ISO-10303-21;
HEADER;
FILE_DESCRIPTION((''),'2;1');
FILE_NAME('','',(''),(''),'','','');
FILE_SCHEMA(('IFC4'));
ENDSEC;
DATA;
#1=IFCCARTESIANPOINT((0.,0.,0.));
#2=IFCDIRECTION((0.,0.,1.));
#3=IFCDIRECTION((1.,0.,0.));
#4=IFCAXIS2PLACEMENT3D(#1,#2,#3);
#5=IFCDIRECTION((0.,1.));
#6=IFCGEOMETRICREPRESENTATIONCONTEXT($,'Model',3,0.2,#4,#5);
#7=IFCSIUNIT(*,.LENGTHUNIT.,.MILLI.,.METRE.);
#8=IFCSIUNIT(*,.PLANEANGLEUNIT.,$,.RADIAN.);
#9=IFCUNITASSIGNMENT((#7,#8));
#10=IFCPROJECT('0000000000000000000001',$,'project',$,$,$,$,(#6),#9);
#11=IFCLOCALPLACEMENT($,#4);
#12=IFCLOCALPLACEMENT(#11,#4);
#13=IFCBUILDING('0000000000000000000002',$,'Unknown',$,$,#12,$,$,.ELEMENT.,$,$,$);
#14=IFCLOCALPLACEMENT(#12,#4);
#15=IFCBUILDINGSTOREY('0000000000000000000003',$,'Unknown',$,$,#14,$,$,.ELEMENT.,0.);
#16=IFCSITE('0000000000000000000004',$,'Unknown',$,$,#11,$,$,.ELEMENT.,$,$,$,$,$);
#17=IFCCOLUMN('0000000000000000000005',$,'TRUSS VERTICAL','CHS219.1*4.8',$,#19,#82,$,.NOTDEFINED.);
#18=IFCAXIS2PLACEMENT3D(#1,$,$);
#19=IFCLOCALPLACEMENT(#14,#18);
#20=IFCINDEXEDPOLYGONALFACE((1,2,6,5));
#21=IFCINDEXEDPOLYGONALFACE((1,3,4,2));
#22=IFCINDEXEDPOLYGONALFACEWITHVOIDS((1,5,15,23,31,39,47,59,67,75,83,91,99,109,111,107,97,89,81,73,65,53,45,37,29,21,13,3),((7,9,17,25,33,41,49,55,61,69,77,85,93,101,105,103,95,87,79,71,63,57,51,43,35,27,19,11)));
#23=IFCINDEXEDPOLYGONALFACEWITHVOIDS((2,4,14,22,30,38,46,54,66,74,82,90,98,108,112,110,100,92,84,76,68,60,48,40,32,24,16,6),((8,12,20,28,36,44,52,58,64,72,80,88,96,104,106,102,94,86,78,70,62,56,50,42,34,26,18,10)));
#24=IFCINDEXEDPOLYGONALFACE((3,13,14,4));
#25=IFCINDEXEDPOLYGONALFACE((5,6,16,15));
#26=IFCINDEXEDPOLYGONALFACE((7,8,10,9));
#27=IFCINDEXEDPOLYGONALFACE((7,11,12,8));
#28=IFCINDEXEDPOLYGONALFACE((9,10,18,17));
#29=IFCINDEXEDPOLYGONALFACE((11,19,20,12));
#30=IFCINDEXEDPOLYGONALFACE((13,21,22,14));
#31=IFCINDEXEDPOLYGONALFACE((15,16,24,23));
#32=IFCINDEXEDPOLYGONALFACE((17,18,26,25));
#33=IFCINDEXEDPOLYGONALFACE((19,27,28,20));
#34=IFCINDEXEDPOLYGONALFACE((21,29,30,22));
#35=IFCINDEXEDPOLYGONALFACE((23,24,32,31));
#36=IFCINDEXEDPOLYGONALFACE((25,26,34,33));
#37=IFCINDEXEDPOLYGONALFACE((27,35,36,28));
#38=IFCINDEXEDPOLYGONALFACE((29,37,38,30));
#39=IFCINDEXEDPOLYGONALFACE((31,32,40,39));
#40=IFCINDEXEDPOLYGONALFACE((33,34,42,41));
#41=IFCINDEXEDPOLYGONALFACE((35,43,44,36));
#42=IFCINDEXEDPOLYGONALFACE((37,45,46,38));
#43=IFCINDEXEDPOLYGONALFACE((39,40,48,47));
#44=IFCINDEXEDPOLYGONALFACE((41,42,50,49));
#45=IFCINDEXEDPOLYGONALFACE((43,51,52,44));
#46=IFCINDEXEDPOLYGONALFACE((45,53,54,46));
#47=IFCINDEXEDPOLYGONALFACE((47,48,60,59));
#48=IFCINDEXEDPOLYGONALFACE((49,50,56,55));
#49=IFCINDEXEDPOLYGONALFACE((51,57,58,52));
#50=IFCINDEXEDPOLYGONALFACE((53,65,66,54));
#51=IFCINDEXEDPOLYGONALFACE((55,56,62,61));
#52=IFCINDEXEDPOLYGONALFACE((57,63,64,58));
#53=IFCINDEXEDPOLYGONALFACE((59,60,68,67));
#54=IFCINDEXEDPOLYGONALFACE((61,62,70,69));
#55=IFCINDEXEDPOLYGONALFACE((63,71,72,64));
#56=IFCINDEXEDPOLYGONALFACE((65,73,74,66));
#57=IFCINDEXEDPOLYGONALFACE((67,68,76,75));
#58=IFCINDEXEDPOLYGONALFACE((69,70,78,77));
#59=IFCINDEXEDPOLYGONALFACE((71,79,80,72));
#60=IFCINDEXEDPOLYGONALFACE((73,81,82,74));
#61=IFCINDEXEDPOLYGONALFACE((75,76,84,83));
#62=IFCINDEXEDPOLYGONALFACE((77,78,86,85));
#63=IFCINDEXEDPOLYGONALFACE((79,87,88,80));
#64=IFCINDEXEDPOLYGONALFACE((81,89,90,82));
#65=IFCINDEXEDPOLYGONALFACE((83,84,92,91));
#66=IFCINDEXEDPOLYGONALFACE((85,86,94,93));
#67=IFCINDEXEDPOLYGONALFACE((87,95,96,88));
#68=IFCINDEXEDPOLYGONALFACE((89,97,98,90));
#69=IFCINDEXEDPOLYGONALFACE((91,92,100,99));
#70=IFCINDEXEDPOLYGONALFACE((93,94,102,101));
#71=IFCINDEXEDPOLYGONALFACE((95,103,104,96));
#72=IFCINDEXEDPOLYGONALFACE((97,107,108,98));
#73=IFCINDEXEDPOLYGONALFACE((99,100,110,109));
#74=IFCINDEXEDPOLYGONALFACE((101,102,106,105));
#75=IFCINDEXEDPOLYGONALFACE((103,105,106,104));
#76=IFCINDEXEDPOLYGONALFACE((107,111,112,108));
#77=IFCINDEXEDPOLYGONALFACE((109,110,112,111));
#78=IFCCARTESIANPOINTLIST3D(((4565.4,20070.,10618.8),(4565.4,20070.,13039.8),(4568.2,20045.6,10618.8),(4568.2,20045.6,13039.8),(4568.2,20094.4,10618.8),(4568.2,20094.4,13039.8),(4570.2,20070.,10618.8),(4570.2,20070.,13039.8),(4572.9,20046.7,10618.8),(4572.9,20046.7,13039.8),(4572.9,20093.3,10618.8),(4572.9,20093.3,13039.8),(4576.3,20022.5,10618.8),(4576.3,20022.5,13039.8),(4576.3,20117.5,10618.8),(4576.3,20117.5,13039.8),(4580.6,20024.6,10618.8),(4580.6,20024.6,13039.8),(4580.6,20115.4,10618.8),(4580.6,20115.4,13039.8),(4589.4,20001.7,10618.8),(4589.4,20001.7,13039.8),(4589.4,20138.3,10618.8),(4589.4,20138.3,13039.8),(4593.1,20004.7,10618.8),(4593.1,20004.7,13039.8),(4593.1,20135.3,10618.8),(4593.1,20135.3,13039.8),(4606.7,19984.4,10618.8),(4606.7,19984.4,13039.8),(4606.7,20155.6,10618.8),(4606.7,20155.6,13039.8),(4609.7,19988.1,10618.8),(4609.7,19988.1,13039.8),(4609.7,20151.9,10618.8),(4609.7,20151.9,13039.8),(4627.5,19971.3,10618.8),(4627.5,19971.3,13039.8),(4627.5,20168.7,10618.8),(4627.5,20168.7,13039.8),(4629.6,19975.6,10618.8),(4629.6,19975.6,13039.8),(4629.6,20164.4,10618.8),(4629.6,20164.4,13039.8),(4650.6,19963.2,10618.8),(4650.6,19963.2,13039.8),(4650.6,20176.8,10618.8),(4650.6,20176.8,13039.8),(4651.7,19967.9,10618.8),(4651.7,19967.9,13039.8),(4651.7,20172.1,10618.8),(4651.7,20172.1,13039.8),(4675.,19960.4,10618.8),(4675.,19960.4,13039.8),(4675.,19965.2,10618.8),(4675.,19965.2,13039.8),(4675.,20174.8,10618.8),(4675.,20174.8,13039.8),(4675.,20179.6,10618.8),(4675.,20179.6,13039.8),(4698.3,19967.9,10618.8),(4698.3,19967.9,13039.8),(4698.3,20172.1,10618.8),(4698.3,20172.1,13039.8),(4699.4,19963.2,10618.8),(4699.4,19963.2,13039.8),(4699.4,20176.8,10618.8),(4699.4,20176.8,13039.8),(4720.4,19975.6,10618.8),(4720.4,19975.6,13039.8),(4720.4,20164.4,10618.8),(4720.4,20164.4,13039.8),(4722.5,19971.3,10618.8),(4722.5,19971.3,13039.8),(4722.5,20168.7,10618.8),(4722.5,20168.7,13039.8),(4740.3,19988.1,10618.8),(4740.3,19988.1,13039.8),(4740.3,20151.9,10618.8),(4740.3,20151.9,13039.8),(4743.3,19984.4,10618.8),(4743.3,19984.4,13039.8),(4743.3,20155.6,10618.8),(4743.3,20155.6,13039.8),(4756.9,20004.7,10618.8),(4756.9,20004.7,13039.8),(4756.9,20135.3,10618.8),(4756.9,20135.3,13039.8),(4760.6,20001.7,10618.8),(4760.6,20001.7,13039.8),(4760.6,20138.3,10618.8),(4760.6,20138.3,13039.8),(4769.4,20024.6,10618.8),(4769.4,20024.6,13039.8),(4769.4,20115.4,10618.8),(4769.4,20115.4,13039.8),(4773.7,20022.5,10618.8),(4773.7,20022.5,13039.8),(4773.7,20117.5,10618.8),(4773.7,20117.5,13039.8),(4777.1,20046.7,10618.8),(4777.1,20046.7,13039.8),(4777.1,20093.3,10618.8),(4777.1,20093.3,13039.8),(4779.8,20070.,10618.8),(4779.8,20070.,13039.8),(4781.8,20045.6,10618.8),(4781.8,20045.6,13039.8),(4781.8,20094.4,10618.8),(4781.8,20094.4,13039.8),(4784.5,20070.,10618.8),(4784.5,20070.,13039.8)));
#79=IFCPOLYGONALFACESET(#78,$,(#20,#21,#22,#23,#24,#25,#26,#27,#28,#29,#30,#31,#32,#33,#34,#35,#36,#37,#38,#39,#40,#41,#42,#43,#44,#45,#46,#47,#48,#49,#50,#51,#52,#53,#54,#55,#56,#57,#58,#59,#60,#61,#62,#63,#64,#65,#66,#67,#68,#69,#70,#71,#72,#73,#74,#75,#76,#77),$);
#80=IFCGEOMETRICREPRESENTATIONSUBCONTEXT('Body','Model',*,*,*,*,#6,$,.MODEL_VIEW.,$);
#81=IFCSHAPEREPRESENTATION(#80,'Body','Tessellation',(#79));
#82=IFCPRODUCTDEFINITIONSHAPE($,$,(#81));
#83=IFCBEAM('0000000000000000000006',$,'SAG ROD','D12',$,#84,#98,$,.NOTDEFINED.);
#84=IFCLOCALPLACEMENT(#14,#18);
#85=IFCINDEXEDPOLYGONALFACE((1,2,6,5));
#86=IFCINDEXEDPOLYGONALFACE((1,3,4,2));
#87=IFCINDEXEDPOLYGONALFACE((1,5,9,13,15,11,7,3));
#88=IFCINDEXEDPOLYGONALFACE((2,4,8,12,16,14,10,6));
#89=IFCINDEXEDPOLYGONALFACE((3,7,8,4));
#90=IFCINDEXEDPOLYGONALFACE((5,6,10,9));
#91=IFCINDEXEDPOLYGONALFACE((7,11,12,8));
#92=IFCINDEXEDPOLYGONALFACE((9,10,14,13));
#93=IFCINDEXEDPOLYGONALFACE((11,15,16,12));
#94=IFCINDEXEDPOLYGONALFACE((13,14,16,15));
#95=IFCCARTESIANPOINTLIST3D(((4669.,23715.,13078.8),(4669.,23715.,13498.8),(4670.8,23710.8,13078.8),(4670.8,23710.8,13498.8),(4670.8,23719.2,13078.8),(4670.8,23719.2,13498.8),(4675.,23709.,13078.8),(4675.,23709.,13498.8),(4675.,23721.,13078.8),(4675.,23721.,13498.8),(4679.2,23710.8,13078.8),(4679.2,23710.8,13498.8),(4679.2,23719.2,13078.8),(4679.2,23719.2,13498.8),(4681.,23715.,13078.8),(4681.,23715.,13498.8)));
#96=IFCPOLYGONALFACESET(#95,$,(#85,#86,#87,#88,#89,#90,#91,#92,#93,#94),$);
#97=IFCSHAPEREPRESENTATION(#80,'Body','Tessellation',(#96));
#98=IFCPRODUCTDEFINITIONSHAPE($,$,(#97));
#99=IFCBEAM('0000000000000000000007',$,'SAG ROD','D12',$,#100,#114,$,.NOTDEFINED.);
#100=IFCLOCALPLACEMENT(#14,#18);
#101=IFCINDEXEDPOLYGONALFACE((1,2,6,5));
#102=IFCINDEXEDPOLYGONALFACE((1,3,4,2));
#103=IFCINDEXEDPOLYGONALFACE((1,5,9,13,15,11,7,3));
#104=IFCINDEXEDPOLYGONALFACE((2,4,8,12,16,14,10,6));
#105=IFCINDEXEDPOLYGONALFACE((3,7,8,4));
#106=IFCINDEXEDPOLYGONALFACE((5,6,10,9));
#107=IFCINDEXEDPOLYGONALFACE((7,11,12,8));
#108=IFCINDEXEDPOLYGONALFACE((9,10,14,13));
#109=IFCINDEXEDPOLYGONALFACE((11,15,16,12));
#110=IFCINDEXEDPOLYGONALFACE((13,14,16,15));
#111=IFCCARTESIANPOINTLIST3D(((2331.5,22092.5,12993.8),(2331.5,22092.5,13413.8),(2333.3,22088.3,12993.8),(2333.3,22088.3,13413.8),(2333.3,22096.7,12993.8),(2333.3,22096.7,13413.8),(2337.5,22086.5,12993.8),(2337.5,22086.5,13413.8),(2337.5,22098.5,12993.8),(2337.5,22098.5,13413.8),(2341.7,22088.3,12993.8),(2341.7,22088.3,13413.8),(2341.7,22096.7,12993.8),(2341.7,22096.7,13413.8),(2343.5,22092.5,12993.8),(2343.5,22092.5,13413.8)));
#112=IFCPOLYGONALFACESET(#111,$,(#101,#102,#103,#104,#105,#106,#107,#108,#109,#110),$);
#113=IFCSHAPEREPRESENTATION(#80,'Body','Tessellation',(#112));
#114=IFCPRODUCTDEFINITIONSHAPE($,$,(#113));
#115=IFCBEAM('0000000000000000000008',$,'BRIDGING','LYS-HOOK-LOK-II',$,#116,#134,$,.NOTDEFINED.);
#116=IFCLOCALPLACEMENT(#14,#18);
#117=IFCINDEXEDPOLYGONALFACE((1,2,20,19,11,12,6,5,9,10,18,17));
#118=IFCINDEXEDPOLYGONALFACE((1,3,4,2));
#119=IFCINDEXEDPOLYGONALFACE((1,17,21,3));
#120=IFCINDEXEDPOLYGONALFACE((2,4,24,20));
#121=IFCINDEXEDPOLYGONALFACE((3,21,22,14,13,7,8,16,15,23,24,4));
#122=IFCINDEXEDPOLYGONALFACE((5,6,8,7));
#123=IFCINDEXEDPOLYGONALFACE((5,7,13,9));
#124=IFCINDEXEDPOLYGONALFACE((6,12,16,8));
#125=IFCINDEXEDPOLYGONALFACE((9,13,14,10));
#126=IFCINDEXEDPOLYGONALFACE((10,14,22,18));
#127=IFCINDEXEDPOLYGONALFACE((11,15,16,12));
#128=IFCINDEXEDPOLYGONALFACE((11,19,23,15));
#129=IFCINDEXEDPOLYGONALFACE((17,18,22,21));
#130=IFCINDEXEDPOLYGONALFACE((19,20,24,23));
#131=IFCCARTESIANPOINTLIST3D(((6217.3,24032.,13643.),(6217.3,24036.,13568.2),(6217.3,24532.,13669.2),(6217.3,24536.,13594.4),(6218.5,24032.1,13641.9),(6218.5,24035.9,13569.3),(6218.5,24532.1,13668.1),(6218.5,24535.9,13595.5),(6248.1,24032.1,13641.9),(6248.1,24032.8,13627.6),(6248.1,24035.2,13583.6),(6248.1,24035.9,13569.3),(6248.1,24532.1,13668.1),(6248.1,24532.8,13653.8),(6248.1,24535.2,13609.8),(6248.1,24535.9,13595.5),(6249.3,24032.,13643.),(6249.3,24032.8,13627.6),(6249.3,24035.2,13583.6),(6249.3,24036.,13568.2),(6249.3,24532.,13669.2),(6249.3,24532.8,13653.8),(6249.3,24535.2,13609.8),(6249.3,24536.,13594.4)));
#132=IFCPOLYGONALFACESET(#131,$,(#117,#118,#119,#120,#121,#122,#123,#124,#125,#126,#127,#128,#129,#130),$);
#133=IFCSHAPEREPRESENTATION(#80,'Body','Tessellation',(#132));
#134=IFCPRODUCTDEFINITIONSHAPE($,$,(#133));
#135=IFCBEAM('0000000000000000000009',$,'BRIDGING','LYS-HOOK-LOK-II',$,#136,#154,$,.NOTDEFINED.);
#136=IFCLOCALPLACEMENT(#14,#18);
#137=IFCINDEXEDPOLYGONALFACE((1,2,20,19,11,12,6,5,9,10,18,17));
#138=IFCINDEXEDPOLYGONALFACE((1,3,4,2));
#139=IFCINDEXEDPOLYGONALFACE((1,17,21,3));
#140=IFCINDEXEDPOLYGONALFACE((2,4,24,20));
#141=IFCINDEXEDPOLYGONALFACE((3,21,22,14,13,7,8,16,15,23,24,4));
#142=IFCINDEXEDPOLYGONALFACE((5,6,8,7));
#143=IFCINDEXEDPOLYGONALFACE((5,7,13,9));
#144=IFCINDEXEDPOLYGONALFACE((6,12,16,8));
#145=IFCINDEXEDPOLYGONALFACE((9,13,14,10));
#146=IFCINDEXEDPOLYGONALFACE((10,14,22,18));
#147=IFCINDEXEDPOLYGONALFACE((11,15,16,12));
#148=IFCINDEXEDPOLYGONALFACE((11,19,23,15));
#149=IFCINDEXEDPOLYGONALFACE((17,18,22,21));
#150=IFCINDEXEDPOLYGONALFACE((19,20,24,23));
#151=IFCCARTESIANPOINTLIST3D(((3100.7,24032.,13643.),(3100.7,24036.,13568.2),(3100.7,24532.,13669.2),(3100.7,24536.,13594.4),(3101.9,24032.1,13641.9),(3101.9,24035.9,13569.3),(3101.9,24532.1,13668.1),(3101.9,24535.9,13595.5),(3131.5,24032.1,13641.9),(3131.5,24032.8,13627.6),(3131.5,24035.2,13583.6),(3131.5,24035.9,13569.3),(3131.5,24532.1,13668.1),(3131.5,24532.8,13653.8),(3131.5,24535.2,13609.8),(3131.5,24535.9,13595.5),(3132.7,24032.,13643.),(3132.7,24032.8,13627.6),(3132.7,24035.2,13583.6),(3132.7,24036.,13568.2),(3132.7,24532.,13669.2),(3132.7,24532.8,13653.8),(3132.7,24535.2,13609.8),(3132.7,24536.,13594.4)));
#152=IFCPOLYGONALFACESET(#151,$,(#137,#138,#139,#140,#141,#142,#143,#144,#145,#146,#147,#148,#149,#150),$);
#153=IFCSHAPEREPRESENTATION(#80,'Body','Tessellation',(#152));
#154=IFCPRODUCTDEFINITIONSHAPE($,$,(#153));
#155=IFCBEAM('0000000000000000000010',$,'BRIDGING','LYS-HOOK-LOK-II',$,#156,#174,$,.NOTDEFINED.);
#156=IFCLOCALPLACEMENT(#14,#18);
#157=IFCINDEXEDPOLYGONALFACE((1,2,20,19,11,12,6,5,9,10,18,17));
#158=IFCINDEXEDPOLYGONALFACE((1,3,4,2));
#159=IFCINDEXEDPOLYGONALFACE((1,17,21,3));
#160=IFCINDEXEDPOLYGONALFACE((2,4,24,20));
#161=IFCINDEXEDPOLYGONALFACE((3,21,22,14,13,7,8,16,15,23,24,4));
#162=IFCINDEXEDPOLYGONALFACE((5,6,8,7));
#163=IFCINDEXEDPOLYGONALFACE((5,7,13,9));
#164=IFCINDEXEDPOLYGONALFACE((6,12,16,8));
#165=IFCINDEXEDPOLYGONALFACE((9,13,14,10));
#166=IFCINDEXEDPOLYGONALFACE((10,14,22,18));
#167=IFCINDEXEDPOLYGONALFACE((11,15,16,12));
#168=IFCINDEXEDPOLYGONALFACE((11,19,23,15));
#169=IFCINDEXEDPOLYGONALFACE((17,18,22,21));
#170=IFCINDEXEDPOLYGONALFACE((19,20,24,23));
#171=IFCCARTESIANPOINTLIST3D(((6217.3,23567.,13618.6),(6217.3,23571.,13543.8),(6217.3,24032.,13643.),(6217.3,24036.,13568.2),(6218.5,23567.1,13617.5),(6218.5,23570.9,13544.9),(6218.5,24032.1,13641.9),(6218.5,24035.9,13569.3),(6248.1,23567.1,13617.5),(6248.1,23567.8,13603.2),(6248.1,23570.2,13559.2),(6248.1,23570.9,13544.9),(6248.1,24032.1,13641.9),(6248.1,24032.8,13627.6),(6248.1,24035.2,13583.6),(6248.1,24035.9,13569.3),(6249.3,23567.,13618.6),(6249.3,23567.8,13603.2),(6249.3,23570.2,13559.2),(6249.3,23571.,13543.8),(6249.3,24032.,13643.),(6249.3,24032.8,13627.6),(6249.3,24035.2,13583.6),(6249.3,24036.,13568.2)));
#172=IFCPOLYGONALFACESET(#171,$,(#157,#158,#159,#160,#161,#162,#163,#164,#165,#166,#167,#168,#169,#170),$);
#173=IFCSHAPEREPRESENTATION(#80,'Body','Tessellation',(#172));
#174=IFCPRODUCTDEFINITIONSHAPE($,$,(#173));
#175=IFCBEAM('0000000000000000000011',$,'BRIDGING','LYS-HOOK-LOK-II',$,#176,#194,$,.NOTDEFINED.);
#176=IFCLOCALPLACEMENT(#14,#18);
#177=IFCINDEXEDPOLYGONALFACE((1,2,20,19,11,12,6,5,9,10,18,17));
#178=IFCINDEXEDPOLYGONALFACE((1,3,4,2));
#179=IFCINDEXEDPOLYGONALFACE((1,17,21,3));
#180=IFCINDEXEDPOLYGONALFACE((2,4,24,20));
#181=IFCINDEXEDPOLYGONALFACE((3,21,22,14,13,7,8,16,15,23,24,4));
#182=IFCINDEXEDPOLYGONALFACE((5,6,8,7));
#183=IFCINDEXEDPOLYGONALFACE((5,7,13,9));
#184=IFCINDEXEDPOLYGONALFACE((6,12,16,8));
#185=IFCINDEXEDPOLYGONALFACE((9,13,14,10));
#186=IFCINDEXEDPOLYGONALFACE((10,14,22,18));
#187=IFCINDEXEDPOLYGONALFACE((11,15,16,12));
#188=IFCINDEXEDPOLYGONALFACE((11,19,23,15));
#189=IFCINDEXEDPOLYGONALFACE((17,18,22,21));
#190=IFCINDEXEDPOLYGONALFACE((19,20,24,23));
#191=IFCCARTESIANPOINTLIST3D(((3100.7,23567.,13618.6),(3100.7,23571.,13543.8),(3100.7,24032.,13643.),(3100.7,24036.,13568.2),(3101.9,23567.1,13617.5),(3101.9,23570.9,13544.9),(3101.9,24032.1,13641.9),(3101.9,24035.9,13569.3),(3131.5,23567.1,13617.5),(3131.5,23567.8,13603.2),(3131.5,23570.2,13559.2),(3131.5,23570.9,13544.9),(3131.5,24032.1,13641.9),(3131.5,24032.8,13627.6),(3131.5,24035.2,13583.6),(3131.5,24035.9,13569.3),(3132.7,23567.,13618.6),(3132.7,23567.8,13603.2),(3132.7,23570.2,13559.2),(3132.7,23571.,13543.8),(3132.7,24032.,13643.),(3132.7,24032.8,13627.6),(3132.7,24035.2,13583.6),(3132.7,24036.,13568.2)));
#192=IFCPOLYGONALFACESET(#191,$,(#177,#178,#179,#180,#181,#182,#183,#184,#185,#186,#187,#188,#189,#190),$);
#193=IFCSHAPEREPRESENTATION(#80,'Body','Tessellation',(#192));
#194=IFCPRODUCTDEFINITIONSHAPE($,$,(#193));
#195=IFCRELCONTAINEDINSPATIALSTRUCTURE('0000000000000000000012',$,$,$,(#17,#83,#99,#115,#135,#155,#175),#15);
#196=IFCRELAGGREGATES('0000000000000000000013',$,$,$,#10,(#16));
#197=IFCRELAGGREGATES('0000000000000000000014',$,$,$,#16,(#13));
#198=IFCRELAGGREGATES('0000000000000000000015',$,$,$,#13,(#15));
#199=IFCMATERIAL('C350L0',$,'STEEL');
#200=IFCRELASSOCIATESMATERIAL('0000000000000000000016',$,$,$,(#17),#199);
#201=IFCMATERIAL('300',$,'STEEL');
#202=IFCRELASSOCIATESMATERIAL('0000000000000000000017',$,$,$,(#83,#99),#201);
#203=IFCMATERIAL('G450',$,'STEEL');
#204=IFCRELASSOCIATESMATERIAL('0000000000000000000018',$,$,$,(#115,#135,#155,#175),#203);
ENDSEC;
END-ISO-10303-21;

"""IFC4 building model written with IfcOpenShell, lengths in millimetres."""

from ifc_helpers import new_model, si_unit, direction, frame, origin_with_axes, place, context, subcontext, project, spatial, line, indexed_curve, outline, extrude, material, element, save


model = new_model("IFC4")

# Units and contexts
model_context = context("Model", 3, precision=0.2, world=origin_with_axes(), true_north=direction((0.0, 1.0)))
body_context = subcontext(model_context, "Body", "Model", "MODEL_VIEW")
ifc_project = project(units=[si_unit("LENGTHUNIT", "METRE", prefix="MILLI"), si_unit("PLANEANGLEUNIT", "RADIAN")], contexts=[model_context])

# Site, building, storey
site_placement = place(None, origin_with_axes())
site = spatial("IfcSite", under=ifc_project, at=site_placement, Name="Unknown", CompositionType="ELEMENT")
building_placement = place(site_placement, origin_with_axes())
building = spatial("IfcBuilding", under=site, at=building_placement, Name="Unknown", CompositionType="ELEMENT")
storey_placement = place(building_placement, origin_with_axes())
storey = spatial("IfcBuildingStorey", under=building, at=storey_placement, Name="Unknown", CompositionType="ELEMENT", Elevation=0.0)

# Column
ifc_material_1 = material(Name="C350L0", Category="STEEL")
column_placement = place(storey_placement, frame((4675.0, 20070.0, 10618.8), z_axis=(-1.0, 0.0, 0.0), x_axis=(0.0, 0.0, 1.0)))
element("IfcColumn", 1, at=column_placement, inside=storey, material=ifc_material_1, Name="TRUSS VERTICAL", Description="CHS219.1*4.8", PredefinedType="NOTDEFINED", context=body_context, shape_type="SolidModel", body=[
    extrude(outline(indexed_curve([(109.5, 0.0), (106.8, 24.4), (98.7, 47.5), (85.6, 68.3), (68.3, 85.6), (47.5, 98.7), (24.4, 106.8), (0.0, 109.5), (-24.4, 106.8), (-47.5, 98.7), (-68.3, 85.6), (-85.6, 68.3), (-98.7, 47.5), (-106.8, 24.4), (-109.5, 0.0), (-106.8, -24.4), (-98.7, -47.5), (-85.6, -68.3), (-68.3, -85.6), (-47.5, -98.7), (-24.4, -106.8), (0.0, -109.5), (24.4, -106.8), (47.5, -98.7), (68.3, -85.6), (85.6, -68.3), (98.7, -47.5), (106.8, -24.4)], segments=[line(1, 2, 3, 4, 5, 6, 7, 8, 9, 10, 11, 12, 13, 14, 15, 16, 17, 18, 19, 20, 21, 22, 23, 24, 25, 26, 27, 28, 1)]), holes=[indexed_curve([(104.8, 0.0), (102.1, -23.3), (94.4, -45.4), (81.9, -65.3), (65.3, -81.9), (45.4, -94.4), (23.3, -102.1), (0.0, -104.8), (-23.3, -102.1), (-45.4, -94.4), (-65.3, -81.9), (-81.9, -65.3), (-94.4, -45.4), (-102.1, -23.3), (-104.8, 0.0), (-102.1, 23.3), (-94.4, 45.4), (-81.9, 65.3), (-65.3, 81.9), (-45.4, 94.4), (-23.3, 102.1), (0.0, 104.8), (23.3, 102.1), (45.4, 94.4), (65.3, 81.9), (81.9, 65.3), (94.4, 45.4), (102.1, 23.3)], segments=[line(1, 2, 3, 4, 5, 6, 7, 8, 9, 10, 11, 12, 13, 14, 15, 16, 17, 18, 19, 20, 21, 22, 23, 24, 25, 26, 27, 28, 1)])]), frame((0.0, 0.0, 0.0), z_axis=(-1.0, 0.0, 0.0), x_axis=(0.0, 0.0, 1.0)), (0.0, 0.0, -1.0), 2421.0),
])

# Beams
ifc_material_2 = material(Name="300", Category="STEEL")
for number, where, z_axis, x_axis, name in (
    (2, (4675.0, 23715.0, 13498.8), (1.0, 0.0, 0.0), (0.0, 0.0, -1.0), "SAG ROD"),
    (3, (2337.5, 22092.5, 13413.8), (1.0, 0.0, 0.0), (0.0, 0.0, -1.0), "SAG ROD"),
):
    element("IfcBeam", number, at=place(storey_placement, frame(where, z_axis=z_axis, x_axis=x_axis)), inside=storey, material=ifc_material_2, Name=name, Description="D12", PredefinedType="NOTDEFINED", context=body_context, shape_type="SolidModel", body=[
        extrude(outline(indexed_curve([(6.0, 0.0), (4.2, 4.2), (0.0, 6.0), (-4.2, 4.2), (-6.0, 0.0), (-4.2, -4.2), (0.0, -6.0), (4.2, -4.2)], segments=[line(1, 2, 3, 4, 5, 6, 7, 8, 1)])), frame((0.0, 0.0, 0.0), z_axis=(-1.0, 0.0, 0.0), x_axis=(0.0, 0.0, 1.0)), (0.0, 0.0, -1.0), 420.0),
    ])
ifc_material_3 = material(Name="G450", Category="STEEL")
for number, where, z_axis, x_axis, name in (
    (4, (6233.3, 24034.0, 13605.6), (1.0, 0.0, 0.0), (0.0, 0.99863, 0.052328), "BRIDGING"),
    (5, (3116.7, 24034.0, 13605.6), (1.0, 0.0, 0.0), (0.0, 0.99863, 0.052328), "BRIDGING"),
):
    element("IfcBeam", number, at=place(storey_placement, frame(where, z_axis=z_axis, x_axis=x_axis)), inside=storey, material=ifc_material_3, Name=name, Description="LYS-HOOK-LOK-II", PredefinedType="NOTDEFINED", context=body_context, shape_type="SolidModel", body=[
        extrude(outline(indexed_curve([(16.0, -37.5), (16.0, -22.0), (14.8, -22.0), (14.8, -36.3), (-14.8, -36.3), (-14.8, 36.3), (14.8, 36.3), (14.8, 22.0), (16.0, 22.0), (16.0, 37.5), (-16.0, 37.5), (-16.0, -37.5)], segments=[line(1, 2, 3, 4, 5, 6, 7, 8, 9, 10, 11, 12, 1)])), frame((0.0, 0.0, 0.0), z_axis=(-1.0, 0.0, 0.0), x_axis=(0.0, 0.0, 1.0)), (0.0, 0.0, -1.0), 500.7),
    ])
for number, where, z_axis, x_axis, name in (
    (6, (6233.3, 23569.0, 13581.2), (1.0, 0.0, 0.0), (0.0, 0.998626, 0.052401), "BRIDGING"),
    (7, (3116.7, 23569.0, 13581.2), (1.0, 0.0, 0.0), (0.0, 0.998626, 0.052401), "BRIDGING"),
):
    element("IfcBeam", number, at=place(storey_placement, frame(where, z_axis=z_axis, x_axis=x_axis)), inside=storey, material=ifc_material_3, Name=name, Description="LYS-HOOK-LOK-II", PredefinedType="NOTDEFINED", context=body_context, shape_type="SolidModel", body=[
        extrude(outline(indexed_curve([(16.0, -37.5), (16.0, -22.0), (14.8, -22.0), (14.8, -36.3), (-14.8, -36.3), (-14.8, 36.3), (14.8, 36.3), (14.8, 22.0), (16.0, 22.0), (16.0, 37.5), (-16.0, 37.5), (-16.0, -37.5)], segments=[line(1, 2, 3, 4, 5, 6, 7, 8, 9, 10, 11, 12, 1)])), frame((0.0, 0.0, 0.0), z_axis=(-1.0, 0.0, 0.0), x_axis=(0.0, 0.0, 1.0)), (0.0, 0.0, -1.0), 465.6),
    ])

save(model, "model.ifc")
